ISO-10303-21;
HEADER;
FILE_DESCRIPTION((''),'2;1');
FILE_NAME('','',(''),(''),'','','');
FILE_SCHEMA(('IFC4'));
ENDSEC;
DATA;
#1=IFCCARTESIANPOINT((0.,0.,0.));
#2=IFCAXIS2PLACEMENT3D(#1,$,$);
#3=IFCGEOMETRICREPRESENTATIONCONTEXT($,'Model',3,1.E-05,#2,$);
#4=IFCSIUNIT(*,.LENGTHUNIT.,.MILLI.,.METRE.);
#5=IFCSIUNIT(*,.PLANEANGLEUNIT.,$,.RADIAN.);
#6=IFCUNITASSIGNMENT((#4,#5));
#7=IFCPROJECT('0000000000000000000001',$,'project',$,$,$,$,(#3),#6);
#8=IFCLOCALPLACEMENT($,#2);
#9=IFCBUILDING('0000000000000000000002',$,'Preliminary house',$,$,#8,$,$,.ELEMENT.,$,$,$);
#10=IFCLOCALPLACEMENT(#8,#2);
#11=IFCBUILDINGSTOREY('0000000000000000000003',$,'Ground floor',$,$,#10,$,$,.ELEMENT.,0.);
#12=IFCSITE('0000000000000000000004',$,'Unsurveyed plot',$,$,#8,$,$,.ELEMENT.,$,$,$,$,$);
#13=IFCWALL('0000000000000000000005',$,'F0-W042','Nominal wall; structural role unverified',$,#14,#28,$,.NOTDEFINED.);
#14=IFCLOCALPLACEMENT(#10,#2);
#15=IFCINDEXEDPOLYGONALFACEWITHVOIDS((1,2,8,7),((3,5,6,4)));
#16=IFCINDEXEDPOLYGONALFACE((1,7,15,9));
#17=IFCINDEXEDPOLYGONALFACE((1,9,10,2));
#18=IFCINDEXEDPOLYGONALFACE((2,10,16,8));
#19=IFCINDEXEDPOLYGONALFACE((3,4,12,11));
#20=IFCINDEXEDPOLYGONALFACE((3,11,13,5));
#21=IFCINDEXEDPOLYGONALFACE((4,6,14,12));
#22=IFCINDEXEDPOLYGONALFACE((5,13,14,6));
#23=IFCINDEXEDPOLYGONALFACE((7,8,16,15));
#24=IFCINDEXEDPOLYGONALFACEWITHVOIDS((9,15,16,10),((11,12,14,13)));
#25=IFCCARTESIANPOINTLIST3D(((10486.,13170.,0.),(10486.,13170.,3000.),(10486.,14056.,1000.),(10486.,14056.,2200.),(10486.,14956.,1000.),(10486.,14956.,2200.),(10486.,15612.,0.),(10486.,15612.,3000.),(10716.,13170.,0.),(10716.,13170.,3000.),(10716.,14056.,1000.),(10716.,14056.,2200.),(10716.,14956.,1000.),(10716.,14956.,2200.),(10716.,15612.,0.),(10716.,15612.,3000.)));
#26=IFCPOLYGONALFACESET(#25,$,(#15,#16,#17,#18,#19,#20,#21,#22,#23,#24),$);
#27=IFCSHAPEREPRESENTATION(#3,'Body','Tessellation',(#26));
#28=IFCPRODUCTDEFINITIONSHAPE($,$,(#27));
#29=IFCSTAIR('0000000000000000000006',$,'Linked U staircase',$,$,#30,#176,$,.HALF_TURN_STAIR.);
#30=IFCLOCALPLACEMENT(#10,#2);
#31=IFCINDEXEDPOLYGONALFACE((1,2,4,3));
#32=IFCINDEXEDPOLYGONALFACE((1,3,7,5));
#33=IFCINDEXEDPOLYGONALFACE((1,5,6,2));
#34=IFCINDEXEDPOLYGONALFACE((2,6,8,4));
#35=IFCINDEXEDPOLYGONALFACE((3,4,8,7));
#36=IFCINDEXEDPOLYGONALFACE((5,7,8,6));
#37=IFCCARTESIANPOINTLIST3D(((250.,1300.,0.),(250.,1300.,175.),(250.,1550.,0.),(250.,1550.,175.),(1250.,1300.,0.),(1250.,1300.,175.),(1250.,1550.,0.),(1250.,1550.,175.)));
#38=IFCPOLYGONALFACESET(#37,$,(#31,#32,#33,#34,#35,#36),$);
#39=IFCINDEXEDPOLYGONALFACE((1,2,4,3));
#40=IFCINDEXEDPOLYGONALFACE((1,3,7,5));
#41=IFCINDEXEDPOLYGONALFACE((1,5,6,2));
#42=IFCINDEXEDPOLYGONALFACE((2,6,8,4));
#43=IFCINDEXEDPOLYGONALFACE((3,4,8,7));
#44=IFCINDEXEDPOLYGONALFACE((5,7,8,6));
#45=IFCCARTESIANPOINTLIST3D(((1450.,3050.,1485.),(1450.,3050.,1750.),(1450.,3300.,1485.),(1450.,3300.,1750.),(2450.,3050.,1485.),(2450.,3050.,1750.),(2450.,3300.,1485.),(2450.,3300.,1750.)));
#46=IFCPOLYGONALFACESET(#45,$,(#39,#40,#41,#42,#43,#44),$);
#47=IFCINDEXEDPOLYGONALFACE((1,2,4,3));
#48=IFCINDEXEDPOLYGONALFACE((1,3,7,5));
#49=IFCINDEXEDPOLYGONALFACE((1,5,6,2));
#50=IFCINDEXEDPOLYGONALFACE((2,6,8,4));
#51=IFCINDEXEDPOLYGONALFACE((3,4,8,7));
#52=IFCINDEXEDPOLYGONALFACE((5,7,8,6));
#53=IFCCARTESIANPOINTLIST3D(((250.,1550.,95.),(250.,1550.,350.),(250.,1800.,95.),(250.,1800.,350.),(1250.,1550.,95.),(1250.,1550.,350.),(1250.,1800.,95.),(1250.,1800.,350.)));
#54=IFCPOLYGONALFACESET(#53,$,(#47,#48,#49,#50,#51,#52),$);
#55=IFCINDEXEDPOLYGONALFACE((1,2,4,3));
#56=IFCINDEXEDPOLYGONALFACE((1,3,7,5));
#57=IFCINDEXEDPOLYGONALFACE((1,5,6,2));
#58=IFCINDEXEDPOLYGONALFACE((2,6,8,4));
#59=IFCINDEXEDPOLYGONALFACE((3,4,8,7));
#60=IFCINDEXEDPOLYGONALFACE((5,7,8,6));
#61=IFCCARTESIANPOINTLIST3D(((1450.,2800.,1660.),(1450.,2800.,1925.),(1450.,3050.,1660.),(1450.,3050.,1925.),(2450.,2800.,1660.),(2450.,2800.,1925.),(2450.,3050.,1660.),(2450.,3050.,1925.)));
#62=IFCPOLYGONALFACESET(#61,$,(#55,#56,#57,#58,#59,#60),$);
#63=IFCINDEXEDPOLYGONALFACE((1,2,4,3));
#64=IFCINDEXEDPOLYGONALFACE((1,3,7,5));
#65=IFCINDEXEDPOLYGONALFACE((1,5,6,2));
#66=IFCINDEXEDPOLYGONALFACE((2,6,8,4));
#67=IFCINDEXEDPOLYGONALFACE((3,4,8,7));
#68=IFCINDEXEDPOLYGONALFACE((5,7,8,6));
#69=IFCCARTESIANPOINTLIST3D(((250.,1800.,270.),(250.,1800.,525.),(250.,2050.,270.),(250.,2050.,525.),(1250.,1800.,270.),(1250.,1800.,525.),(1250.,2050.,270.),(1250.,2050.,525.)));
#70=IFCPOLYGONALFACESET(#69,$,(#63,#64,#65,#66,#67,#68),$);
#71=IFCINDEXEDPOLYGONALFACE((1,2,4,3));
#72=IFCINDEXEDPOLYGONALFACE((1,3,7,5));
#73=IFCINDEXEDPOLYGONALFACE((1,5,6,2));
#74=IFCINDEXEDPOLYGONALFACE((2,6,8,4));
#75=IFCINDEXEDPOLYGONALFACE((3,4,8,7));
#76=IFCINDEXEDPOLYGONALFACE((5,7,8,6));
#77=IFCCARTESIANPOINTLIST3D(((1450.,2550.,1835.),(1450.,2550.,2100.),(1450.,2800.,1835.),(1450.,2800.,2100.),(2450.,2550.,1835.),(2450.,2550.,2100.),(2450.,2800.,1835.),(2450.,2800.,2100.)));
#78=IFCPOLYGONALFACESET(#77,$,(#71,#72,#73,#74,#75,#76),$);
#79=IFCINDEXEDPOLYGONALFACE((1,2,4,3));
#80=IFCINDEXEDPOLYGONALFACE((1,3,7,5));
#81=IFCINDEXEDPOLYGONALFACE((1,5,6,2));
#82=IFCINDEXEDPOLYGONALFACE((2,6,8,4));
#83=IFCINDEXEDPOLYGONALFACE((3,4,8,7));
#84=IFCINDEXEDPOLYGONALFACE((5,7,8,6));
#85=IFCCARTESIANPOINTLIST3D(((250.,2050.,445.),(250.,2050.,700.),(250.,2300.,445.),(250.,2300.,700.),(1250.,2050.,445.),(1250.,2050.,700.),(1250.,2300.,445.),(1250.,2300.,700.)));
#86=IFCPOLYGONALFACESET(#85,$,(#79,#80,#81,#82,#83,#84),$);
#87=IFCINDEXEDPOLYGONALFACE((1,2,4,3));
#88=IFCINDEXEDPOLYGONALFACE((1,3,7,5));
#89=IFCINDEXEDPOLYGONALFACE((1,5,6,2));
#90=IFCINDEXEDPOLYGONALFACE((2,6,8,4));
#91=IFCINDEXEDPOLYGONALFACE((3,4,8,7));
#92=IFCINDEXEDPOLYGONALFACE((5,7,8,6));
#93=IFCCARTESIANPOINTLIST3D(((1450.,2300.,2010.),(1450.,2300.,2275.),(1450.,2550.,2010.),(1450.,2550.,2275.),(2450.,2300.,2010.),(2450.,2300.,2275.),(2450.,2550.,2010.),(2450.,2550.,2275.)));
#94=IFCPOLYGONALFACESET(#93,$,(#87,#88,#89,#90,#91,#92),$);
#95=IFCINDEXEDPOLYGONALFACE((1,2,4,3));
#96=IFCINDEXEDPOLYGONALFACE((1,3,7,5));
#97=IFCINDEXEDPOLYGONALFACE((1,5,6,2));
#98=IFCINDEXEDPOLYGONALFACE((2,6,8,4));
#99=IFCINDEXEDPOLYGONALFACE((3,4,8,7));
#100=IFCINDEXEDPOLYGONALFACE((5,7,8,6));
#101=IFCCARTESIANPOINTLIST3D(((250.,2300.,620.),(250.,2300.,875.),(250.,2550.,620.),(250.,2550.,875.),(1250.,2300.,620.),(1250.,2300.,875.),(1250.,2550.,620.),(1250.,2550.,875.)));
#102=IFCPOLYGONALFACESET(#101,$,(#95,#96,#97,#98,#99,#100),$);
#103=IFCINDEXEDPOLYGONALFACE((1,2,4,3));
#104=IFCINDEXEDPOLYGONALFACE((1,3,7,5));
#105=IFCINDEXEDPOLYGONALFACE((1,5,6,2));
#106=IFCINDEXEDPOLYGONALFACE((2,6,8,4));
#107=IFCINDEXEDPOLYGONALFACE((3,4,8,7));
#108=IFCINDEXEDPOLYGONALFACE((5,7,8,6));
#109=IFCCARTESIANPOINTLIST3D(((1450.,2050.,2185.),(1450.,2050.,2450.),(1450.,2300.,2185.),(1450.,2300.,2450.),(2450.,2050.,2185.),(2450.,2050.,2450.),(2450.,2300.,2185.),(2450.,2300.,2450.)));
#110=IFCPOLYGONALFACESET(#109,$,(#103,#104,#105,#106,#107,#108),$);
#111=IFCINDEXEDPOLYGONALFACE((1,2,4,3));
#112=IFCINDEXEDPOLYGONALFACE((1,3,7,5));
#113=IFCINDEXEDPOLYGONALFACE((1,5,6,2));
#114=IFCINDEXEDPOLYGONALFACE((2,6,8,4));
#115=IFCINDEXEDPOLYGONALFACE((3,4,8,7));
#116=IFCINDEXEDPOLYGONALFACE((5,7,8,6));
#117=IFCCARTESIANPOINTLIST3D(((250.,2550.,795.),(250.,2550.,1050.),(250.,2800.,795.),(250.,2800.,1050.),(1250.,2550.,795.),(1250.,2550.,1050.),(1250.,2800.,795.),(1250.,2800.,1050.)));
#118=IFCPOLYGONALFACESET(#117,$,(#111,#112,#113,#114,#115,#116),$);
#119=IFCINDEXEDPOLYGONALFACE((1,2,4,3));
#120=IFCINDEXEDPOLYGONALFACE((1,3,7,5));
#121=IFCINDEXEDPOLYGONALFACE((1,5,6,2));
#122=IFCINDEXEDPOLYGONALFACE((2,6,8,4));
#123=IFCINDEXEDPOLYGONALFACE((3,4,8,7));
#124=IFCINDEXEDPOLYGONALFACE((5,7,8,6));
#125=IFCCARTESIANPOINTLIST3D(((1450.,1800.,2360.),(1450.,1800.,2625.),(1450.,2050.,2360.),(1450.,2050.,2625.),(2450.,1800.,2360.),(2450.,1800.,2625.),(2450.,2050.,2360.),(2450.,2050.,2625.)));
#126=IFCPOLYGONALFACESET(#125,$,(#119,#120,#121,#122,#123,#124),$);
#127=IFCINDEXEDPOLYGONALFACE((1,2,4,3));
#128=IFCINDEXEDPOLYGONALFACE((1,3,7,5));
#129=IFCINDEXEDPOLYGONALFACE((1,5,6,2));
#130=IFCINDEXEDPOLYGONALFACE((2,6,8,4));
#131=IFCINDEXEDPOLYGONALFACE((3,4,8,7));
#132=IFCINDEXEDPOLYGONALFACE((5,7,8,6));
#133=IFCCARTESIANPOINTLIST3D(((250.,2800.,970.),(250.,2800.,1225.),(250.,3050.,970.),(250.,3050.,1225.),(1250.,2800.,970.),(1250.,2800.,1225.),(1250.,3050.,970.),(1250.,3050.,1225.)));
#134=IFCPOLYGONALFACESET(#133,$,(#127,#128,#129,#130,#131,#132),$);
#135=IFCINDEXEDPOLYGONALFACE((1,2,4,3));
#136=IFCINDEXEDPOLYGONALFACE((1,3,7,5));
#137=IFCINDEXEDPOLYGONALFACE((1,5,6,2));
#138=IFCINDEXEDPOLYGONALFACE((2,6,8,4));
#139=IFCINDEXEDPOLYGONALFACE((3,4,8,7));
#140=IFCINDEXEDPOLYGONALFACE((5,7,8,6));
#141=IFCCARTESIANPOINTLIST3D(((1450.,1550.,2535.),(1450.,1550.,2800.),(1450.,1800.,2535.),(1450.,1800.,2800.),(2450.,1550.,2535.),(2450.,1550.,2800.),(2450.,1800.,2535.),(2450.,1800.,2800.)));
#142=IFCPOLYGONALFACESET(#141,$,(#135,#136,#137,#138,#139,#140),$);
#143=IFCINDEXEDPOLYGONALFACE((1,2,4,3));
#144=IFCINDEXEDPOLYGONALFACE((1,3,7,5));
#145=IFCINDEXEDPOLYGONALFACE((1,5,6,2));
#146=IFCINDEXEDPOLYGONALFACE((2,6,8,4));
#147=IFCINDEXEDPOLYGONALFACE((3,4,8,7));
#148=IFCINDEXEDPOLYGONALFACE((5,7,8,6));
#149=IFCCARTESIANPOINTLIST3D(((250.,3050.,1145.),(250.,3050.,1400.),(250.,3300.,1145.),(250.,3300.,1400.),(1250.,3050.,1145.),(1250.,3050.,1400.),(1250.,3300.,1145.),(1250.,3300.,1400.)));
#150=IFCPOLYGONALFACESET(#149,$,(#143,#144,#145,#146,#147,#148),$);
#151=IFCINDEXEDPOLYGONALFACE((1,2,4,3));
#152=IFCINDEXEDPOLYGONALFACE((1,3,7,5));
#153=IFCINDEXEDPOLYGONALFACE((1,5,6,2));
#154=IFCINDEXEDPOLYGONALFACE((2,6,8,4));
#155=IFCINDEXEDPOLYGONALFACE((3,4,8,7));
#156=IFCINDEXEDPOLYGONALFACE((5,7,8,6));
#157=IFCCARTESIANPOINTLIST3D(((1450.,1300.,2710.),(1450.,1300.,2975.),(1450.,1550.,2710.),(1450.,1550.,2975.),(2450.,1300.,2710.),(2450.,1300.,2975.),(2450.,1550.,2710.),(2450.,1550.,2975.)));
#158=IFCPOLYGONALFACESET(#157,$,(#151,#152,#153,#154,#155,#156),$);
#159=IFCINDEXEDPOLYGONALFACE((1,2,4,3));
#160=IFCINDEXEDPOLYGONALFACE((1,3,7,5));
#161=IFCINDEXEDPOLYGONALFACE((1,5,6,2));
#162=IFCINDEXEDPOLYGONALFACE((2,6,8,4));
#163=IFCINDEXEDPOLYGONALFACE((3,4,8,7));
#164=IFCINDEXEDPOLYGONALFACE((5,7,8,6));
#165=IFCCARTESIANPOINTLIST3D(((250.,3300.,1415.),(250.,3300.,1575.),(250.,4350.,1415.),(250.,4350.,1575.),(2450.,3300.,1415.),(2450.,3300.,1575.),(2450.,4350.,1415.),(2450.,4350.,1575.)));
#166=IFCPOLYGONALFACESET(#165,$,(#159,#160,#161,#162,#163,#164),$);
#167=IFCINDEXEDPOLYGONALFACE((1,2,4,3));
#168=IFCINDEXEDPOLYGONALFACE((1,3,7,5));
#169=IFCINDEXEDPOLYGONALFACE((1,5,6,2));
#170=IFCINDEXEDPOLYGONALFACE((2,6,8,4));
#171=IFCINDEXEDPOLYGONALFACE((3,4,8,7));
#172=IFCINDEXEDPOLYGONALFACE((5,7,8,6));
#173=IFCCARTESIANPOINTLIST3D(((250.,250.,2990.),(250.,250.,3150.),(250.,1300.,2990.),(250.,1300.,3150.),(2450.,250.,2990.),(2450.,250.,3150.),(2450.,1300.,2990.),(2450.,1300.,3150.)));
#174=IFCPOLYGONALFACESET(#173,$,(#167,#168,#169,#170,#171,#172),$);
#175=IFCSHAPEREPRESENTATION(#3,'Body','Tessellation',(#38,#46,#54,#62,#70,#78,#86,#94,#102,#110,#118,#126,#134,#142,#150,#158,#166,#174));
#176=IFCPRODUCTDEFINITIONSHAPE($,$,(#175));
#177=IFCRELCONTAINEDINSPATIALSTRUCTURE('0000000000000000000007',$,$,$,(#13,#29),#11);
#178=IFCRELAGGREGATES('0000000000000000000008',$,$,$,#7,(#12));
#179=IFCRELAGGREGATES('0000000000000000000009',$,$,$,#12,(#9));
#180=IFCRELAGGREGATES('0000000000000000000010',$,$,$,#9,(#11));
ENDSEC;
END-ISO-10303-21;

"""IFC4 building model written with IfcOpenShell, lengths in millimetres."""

from ifc_helpers import new_model, si_unit, frame, origin, place, context, project, spatial, polyline, outline, extrude, element, save


model = new_model("IFC4")

# Units and contexts
model_context = context("Model", 3, precision=1e-05, world=origin())
ifc_project = project(units=[si_unit("LENGTHUNIT", "METRE", prefix="MILLI"), si_unit("PLANEANGLEUNIT", "RADIAN")], contexts=[model_context])

# Site, building, storey
placement_1 = place(None, origin())
site = spatial("IfcSite", under=ifc_project, at=placement_1, Name="Unsurveyed plot", CompositionType="ELEMENT")
building = spatial("IfcBuilding", under=site, at=placement_1, Name="Preliminary house", CompositionType="ELEMENT")
placement_2 = place(placement_1, origin())
storey = spatial("IfcBuildingStorey", under=building, at=placement_2, Name="Ground floor", CompositionType="ELEMENT", Elevation=0.0)

# Wall, opening
wall_1 = element("IfcWall", 1, at=placement_2, inside=storey, Name="F0-W042", Description="Nominal wall; structural role unverified", PredefinedType="NOTDEFINED", context=model_context, shape_type="SweptSolid", body=[
    extrude(outline(polyline([(10486.0, 13170.0), (10486.0, 15612.0), (10716.0, 15612.0), (10716.0, 13170.0), (10486.0, 13170.0)])), origin(), (0.0, 0.0, 1.0), 3000.0),
])
element("IfcOpeningElement", 2, at=placement_2, cuts=wall_1, PredefinedType="OPENING", context=model_context, shape_type="SweptSolid", body=[
    extrude(outline(polyline([(11131.0, 14056.0), (11131.0, 14956.0), (10071.0, 14956.0), (10071.0, 14056.0), (11131.0, 14056.0)])), frame((0.0, 0.0, 1000.0)), (0.0, 0.0, 1.0), 1200.0),
])

# Stair
element("IfcStair", 3, at=placement_2, inside=storey, Name="Linked U staircase", PredefinedType="HALF_TURN_STAIR", context=model_context, shape_type="SweptSolid", body=[
    extrude(outline(polyline([(1250.0, 1300.0), (1250.0, 1550.0), (250.0, 1550.0), (250.0, 1300.0), (1250.0, 1300.0)])), origin(), (0.0, 0.0, 1.0), 175.0),
    extrude(outline(polyline([(2450.0, 3050.0), (2450.0, 3300.0), (1450.0, 3300.0), (1450.0, 3050.0), (2450.0, 3050.0)])), frame((0.0, 0.0, 1485.0)), (0.0, 0.0, 1.0), 265.0),
    extrude(outline(polyline([(1250.0, 1550.0), (1250.0, 1800.0), (250.0, 1800.0), (250.0, 1550.0), (1250.0, 1550.0)])), frame((0.0, 0.0, 95.0)), (0.0, 0.0, 1.0), 255.0),
    extrude(outline(polyline([(2450.0, 2800.0), (2450.0, 3050.0), (1450.0, 3050.0), (1450.0, 2800.0), (2450.0, 2800.0)])), frame((0.0, 0.0, 1660.0)), (0.0, 0.0, 1.0), 265.0),
    extrude(outline(polyline([(1250.0, 1800.0), (1250.0, 2050.0), (250.0, 2050.0), (250.0, 1800.0), (1250.0, 1800.0)])), frame((0.0, 0.0, 270.0)), (0.0, 0.0, 1.0), 255.0),
    extrude(outline(polyline([(2450.0, 2550.0), (2450.0, 2800.0), (1450.0, 2800.0), (1450.0, 2550.0), (2450.0, 2550.0)])), frame((0.0, 0.0, 1835.0)), (0.0, 0.0, 1.0), 265.0),
    extrude(outline(polyline([(1250.0, 2050.0), (1250.0, 2300.0), (250.0, 2300.0), (250.0, 2050.0), (1250.0, 2050.0)])), frame((0.0, 0.0, 445.0)), (0.0, 0.0, 1.0), 255.0),
    extrude(outline(polyline([(2450.0, 2300.0), (2450.0, 2550.0), (1450.0, 2550.0), (1450.0, 2300.0), (2450.0, 2300.0)])), frame((0.0, 0.0, 2010.0)), (0.0, 0.0, 1.0), 265.0),
    extrude(outline(polyline([(1250.0, 2300.0), (1250.0, 2550.0), (250.0, 2550.0), (250.0, 2300.0), (1250.0, 2300.0)])), frame((0.0, 0.0, 620.0)), (0.0, 0.0, 1.0), 255.0),
    extrude(outline(polyline([(2450.0, 2050.0), (2450.0, 2300.0), (1450.0, 2300.0), (1450.0, 2050.0), (2450.0, 2050.0)])), frame((0.0, 0.0, 2185.0)), (0.0, 0.0, 1.0), 265.0),
    extrude(outline(polyline([(1250.0, 2550.0), (1250.0, 2800.0), (250.0, 2800.0), (250.0, 2550.0), (1250.0, 2550.0)])), frame((0.0, 0.0, 795.0)), (0.0, 0.0, 1.0), 255.0),
    extrude(outline(polyline([(2450.0, 1800.0), (2450.0, 2050.0), (1450.0, 2050.0), (1450.0, 1800.0), (2450.0, 1800.0)])), frame((0.0, 0.0, 2360.0)), (0.0, 0.0, 1.0), 265.0),
    extrude(outline(polyline([(1250.0, 2800.0), (1250.0, 3050.0), (250.0, 3050.0), (250.0, 2800.0), (1250.0, 2800.0)])), frame((0.0, 0.0, 970.0)), (0.0, 0.0, 1.0), 255.0),
    extrude(outline(polyline([(2450.0, 1550.0), (2450.0, 1800.0), (1450.0, 1800.0), (1450.0, 1550.0), (2450.0, 1550.0)])), frame((0.0, 0.0, 2535.0)), (0.0, 0.0, 1.0), 265.0),
    extrude(outline(polyline([(1250.0, 3050.0), (1250.0, 3300.0), (250.0, 3300.0), (250.0, 3050.0), (1250.0, 3050.0)])), frame((0.0, 0.0, 1145.0)), (0.0, 0.0, 1.0), 255.0),
    extrude(outline(polyline([(2450.0, 1300.0), (2450.0, 1550.0), (1450.0, 1550.0), (1450.0, 1300.0), (2450.0, 1300.0)])), frame((0.0, 0.0, 2710.0)), (0.0, 0.0, 1.0), 265.0),
    extrude(outline(polyline([(2450.0, 3300.0), (2450.0, 4350.0), (250.0, 4350.0), (250.0, 3300.0), (2450.0, 3300.0)])), frame((0.0, 0.0, 1415.0)), (0.0, 0.0, 1.0), 160.0),
    extrude(outline(polyline([(2450.0, 250.0), (2450.0, 1300.0), (250.0, 1300.0), (250.0, 250.0), (2450.0, 250.0)])), frame((0.0, 0.0, 2990.0)), (0.0, 0.0, 1.0), 160.0),
])

save(model, "model.ifc")
